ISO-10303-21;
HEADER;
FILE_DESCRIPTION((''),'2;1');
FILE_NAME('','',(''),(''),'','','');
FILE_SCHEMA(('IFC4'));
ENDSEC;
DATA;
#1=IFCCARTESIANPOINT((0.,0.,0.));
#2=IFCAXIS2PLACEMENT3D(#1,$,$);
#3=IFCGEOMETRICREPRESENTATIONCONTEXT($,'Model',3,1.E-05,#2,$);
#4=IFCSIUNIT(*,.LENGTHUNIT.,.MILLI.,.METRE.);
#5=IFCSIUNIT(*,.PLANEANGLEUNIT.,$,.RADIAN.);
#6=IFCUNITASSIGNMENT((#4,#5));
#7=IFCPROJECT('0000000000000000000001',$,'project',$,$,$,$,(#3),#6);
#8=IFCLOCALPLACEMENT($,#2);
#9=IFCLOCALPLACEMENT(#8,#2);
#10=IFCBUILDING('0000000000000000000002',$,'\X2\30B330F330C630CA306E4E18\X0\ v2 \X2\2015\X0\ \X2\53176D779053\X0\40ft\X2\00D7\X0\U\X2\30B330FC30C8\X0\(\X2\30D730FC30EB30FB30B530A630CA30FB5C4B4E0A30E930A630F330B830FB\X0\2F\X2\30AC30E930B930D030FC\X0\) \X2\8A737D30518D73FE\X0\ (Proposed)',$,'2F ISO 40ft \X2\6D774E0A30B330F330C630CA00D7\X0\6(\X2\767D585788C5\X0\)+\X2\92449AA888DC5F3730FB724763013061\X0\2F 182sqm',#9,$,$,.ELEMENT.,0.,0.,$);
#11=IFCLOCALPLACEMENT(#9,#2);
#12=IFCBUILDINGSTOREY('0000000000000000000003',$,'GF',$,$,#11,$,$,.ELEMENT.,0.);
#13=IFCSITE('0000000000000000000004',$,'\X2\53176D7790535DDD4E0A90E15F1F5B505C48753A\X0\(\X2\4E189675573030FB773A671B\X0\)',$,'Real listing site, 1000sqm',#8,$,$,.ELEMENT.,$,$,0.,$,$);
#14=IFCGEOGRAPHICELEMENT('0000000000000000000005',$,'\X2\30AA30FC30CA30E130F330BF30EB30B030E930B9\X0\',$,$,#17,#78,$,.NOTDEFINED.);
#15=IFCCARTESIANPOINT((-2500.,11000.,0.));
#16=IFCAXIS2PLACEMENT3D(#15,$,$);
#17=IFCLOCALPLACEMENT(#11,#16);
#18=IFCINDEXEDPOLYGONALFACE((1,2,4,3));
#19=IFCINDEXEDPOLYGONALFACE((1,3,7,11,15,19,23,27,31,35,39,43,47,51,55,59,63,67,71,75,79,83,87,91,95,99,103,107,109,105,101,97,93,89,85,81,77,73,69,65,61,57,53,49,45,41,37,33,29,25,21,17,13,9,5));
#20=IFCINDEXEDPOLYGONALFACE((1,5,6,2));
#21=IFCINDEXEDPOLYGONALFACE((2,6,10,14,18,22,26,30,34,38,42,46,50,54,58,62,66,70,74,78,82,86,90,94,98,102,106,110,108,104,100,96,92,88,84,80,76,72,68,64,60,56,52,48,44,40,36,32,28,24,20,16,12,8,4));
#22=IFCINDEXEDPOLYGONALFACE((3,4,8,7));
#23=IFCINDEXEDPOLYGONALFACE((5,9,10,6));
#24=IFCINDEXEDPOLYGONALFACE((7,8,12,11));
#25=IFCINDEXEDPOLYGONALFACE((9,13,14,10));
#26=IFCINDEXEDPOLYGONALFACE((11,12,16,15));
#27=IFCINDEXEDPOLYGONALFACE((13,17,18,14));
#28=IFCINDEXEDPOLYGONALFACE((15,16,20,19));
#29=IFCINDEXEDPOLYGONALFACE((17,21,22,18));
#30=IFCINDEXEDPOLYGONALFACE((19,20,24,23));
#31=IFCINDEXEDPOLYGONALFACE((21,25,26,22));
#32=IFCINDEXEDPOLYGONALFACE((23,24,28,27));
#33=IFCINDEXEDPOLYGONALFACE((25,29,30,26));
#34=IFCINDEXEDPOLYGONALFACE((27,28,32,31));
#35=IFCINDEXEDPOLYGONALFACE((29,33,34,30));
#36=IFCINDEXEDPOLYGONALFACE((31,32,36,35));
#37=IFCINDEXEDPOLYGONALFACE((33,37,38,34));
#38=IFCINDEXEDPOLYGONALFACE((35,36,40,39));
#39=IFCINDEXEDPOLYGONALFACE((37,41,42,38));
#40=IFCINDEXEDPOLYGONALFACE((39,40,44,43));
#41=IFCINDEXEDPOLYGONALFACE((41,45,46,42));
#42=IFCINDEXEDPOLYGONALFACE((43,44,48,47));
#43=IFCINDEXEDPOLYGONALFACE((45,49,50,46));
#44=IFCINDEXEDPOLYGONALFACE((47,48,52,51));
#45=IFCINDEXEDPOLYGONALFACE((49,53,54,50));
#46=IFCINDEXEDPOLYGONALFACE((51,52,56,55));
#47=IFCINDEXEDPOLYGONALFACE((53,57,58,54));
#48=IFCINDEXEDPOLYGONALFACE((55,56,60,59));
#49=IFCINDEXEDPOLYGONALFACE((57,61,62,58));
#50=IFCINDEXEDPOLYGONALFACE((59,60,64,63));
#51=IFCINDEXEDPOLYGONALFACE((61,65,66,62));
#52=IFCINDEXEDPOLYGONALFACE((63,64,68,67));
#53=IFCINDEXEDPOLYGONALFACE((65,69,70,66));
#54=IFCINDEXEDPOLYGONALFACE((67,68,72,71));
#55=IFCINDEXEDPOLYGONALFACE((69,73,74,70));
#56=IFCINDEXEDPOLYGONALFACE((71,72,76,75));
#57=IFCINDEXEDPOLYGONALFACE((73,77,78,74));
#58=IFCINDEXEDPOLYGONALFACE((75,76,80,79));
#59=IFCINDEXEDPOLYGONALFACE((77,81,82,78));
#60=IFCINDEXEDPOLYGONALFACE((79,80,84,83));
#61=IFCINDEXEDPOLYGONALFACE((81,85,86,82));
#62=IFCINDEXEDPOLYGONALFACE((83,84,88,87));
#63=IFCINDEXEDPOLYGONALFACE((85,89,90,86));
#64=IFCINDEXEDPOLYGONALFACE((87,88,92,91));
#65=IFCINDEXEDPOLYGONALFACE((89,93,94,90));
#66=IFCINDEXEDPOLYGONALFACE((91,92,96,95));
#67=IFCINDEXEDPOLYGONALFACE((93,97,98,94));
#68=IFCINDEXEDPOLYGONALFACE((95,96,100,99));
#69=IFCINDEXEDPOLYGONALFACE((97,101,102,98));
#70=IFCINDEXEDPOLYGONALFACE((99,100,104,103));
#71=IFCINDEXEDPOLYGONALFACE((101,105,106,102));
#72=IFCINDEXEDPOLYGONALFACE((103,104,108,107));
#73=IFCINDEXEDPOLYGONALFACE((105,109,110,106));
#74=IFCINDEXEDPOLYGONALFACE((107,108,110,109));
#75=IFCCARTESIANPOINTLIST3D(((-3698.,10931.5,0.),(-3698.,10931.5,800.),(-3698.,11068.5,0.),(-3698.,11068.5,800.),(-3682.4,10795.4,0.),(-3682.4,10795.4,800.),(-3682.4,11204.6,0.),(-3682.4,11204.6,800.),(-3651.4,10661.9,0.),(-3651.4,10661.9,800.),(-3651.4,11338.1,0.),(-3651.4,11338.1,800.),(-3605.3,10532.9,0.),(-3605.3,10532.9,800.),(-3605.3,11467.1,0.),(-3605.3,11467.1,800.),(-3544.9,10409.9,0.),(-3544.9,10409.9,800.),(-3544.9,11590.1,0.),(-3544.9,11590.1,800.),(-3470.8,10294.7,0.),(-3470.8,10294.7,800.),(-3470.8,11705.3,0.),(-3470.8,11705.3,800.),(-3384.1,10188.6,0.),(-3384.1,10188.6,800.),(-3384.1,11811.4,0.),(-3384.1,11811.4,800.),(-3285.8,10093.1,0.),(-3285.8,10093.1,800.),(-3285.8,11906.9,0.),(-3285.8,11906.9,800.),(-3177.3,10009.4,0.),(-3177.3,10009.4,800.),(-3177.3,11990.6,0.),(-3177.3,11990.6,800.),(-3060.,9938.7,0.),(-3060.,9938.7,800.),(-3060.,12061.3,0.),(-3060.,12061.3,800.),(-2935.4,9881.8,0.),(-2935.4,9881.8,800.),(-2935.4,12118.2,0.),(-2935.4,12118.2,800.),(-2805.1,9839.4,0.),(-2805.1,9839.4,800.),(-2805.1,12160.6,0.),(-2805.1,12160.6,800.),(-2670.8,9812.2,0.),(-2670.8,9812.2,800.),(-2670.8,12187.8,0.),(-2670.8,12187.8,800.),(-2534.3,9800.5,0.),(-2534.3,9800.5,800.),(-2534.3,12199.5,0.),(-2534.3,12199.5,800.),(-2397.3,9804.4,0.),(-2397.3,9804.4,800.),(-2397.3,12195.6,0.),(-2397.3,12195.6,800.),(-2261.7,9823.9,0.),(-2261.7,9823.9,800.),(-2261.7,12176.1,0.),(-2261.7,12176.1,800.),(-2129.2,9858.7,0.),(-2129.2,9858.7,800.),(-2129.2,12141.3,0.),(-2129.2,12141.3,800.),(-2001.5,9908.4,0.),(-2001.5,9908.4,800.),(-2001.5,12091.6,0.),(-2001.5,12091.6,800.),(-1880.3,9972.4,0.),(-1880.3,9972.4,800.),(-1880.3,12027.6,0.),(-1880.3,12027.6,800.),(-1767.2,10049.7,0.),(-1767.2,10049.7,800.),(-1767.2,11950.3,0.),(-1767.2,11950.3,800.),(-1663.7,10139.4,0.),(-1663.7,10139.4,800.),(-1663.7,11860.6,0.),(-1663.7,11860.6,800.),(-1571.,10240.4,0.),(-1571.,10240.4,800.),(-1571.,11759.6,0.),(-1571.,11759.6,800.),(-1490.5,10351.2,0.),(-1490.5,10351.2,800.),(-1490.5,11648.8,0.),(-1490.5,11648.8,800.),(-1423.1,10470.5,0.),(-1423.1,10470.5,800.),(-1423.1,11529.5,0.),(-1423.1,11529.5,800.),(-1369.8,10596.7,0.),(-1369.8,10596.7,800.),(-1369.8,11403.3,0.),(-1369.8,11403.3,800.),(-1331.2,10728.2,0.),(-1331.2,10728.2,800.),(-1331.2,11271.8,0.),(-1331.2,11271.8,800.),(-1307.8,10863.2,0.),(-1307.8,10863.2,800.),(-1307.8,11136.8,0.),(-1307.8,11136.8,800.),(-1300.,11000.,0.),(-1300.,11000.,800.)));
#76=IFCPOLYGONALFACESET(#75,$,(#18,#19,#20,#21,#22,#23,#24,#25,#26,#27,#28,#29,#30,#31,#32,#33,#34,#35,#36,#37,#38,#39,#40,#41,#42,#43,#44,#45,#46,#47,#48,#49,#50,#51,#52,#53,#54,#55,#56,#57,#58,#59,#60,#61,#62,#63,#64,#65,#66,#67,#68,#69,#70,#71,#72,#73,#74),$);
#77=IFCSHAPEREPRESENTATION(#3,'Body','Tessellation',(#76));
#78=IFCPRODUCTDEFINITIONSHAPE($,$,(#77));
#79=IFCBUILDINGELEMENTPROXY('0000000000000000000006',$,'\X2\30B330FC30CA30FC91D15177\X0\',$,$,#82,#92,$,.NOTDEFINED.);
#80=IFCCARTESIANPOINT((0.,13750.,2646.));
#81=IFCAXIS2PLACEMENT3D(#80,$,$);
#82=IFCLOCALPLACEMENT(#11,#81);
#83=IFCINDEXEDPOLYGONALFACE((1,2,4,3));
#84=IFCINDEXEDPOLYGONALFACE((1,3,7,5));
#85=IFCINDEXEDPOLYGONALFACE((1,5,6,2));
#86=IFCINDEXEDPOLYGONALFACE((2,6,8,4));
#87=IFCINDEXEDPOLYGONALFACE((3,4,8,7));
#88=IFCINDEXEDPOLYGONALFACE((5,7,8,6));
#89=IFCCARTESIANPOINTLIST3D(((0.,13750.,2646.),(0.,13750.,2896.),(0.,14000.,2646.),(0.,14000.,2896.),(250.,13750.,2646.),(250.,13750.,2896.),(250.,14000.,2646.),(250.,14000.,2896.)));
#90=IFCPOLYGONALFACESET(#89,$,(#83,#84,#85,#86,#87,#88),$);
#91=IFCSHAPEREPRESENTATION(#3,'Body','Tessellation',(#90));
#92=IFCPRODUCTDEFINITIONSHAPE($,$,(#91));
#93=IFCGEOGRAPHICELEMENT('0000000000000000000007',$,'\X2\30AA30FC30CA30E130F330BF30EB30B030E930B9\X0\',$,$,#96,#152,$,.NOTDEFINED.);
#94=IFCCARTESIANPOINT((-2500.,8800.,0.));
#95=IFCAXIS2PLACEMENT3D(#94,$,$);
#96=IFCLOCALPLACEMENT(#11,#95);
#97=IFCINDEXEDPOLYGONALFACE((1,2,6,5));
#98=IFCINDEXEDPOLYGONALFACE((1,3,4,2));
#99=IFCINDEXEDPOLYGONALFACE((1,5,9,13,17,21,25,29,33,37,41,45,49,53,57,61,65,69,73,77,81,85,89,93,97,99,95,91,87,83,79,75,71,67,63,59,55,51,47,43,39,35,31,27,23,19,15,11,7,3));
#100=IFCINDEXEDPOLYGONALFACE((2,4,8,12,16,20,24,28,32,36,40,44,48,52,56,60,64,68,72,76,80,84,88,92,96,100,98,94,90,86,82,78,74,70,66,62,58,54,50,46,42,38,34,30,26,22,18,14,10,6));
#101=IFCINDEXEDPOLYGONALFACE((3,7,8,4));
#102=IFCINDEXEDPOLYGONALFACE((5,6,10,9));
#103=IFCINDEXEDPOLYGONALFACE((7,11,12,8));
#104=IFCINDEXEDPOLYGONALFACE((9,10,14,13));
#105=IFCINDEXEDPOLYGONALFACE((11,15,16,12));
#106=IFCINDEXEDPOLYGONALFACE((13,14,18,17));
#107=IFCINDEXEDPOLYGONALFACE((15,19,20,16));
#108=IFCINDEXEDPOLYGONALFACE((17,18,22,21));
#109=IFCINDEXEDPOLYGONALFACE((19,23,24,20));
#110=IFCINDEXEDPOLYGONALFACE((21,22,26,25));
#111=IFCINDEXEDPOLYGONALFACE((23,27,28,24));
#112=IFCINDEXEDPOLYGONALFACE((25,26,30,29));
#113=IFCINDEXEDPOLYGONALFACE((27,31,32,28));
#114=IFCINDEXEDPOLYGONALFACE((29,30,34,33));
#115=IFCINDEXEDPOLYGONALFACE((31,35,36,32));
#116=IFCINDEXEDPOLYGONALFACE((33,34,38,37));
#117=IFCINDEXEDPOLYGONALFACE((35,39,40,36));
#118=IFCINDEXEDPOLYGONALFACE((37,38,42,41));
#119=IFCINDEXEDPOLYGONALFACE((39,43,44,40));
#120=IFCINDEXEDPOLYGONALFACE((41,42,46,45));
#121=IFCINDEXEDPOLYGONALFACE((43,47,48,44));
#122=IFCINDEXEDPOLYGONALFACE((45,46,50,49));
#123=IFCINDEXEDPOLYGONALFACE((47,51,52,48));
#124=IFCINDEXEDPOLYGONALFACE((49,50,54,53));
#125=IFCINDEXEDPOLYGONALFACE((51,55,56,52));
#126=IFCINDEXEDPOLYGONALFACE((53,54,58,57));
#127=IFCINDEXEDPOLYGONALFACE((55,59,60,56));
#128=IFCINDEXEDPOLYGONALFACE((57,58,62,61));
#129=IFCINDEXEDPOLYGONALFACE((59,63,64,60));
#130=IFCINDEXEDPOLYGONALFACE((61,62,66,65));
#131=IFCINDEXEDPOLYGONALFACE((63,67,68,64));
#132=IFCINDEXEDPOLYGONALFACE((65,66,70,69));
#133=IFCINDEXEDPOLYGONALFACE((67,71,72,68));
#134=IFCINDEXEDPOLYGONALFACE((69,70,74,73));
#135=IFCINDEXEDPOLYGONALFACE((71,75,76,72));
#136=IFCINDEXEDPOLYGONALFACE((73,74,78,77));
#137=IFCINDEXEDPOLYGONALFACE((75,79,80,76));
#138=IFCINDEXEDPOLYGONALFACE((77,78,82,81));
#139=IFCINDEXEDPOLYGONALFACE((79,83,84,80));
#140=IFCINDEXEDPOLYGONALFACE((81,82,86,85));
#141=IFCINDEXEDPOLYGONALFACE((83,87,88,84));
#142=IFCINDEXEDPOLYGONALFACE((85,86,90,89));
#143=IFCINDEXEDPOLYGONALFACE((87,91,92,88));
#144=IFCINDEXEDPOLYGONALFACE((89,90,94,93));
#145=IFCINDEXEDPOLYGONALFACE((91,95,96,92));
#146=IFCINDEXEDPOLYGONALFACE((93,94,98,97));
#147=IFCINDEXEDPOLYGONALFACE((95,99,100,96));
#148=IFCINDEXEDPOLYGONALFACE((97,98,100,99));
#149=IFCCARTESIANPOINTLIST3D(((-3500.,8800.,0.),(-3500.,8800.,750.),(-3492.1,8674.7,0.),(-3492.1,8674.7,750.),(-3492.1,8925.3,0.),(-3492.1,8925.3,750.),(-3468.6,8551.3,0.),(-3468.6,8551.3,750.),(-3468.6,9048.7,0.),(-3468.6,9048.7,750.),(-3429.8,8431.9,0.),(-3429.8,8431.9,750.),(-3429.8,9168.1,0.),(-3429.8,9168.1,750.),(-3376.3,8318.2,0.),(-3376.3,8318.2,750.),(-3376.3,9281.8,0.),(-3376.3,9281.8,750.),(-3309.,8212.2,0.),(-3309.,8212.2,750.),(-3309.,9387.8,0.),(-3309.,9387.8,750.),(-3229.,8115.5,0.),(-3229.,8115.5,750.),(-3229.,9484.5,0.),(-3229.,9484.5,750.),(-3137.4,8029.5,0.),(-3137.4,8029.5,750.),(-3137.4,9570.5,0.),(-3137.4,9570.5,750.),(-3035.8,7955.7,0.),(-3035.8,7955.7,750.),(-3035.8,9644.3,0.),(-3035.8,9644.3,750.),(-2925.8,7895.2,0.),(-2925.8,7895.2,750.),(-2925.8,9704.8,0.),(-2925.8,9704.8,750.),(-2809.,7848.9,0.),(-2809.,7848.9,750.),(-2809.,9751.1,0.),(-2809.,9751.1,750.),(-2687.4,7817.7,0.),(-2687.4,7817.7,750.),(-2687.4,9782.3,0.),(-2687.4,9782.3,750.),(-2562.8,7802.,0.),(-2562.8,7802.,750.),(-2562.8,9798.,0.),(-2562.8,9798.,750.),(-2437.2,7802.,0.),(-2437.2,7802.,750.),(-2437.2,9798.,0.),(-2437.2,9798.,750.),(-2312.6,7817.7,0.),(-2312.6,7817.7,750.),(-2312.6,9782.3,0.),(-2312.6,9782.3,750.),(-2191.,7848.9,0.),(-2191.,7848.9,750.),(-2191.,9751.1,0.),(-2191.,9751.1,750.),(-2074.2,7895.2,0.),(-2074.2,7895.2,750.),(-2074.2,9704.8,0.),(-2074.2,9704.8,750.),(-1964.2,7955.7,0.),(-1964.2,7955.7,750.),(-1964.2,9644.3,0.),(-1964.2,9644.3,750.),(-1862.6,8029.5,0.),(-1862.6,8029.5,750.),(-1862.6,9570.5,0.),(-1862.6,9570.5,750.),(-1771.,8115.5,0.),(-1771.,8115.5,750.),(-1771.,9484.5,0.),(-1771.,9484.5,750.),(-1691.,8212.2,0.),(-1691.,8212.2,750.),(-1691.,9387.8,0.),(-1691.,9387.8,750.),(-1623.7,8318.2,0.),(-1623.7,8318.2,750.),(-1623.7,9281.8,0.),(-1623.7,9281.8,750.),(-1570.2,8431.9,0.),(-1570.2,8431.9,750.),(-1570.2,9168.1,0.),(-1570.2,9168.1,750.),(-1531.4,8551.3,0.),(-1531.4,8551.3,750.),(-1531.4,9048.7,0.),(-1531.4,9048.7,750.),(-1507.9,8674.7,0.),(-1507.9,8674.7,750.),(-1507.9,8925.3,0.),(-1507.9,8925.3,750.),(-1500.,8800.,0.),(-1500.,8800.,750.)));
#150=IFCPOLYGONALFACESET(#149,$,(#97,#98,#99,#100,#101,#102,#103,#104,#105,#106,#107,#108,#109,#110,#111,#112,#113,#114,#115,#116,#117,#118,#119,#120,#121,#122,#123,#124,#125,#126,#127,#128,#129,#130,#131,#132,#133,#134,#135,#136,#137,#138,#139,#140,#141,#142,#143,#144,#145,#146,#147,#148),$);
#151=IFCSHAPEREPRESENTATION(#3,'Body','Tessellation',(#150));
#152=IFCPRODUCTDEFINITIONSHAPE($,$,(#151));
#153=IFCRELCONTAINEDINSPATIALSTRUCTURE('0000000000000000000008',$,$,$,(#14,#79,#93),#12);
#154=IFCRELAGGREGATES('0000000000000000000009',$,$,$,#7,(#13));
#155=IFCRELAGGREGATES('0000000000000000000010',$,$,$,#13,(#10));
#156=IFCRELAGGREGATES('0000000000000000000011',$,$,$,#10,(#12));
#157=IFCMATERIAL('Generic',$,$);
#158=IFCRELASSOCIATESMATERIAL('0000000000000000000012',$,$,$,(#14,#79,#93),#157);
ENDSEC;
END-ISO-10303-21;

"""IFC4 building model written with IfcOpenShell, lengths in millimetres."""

from ifc_helpers import new_model, si_unit, frame, frame_2d, origin, origin_2d, place, context, project, spatial, rectangle, circle, extrude, material, element, save


model = new_model("IFC4")

# Units and contexts
model_context = context("Model", 3, precision=1e-05, world=origin())
ifc_project = project(units=[si_unit("LENGTHUNIT", "METRE", prefix="MILLI"), si_unit("PLANEANGLEUNIT", "RADIAN")], contexts=[model_context])

# Site, building, storey
site_placement = place(None, origin())
site = spatial("IfcSite", under=ifc_project, at=site_placement, Name="北海道川上郡弟子屈町(丘陵地・眺望)", ObjectType="Real listing site, 1000sqm", CompositionType="ELEMENT", RefElevation=0.0)
building_placement = place(site_placement, origin())
building = spatial("IfcBuilding", under=site, at=building_placement, Name="コンテナの丘 v2 ― 北海道40ft×Uコート(プール・サウナ・屋上ラウンジ・2Fガラスバー) 詳細再現 (Proposed)", ObjectType="2F ISO 40ft 海上コンテナ×6(白塗装)+鉄骨補強・片持ち2F 182sqm", CompositionType="ELEMENT", ElevationOfRefHeight=0.0, ElevationOfTerrain=0.0)
storey_placement = place(building_placement, origin())
storey = spatial("IfcBuildingStorey", under=building, at=storey_placement, Name="GF", CompositionType="ELEMENT", Elevation=0.0)

# Shared definitions
ifc_material = material(Name="Generic")

# Geographic element
geographic_element_1_placement = place(storey_placement, frame((-2500.0, 11000.0, 0.0)))
element("IfcGeographicElement", 1, at=geographic_element_1_placement, inside=storey, material=ifc_material, Name="オーナメンタルグラス", PredefinedType="NOTDEFINED", context=model_context, shape_type="SweptSolid", body=[
    extrude(circle(Radius=1200.0, at=origin_2d()), frame((-2500.0, 11000.0, 0.0)), (0.0, 0.0, 1.0), 800.0),
])

# Building element proxy
proxy_placement = place(storey_placement, frame((0.0, 13750.0, 2646.0)))
element("IfcBuildingElementProxy", 2, at=proxy_placement, inside=storey, material=ifc_material, Name="コーナー金具", PredefinedType="NOTDEFINED", context=model_context, shape_type="SweptSolid", body=[
    extrude(rectangle(XDim=250.0, YDim=250.0, at=frame_2d((125.0, 125.0))), frame((0.0, 13750.0, 2646.0)), (0.0, 0.0, 1.0), 250.0),
])

# Geographic element
geographic_element_2_placement = place(storey_placement, frame((-2500.0, 8800.0, 0.0)))
element("IfcGeographicElement", 3, at=geographic_element_2_placement, inside=storey, material=ifc_material, Name="オーナメンタルグラス", PredefinedType="NOTDEFINED", context=model_context, shape_type="SweptSolid", body=[
    extrude(circle(Radius=1000.0, at=origin_2d()), frame((-2500.0, 8800.0, 0.0)), (0.0, 0.0, 1.0), 750.0),
])

save(model, "model.ifc")
